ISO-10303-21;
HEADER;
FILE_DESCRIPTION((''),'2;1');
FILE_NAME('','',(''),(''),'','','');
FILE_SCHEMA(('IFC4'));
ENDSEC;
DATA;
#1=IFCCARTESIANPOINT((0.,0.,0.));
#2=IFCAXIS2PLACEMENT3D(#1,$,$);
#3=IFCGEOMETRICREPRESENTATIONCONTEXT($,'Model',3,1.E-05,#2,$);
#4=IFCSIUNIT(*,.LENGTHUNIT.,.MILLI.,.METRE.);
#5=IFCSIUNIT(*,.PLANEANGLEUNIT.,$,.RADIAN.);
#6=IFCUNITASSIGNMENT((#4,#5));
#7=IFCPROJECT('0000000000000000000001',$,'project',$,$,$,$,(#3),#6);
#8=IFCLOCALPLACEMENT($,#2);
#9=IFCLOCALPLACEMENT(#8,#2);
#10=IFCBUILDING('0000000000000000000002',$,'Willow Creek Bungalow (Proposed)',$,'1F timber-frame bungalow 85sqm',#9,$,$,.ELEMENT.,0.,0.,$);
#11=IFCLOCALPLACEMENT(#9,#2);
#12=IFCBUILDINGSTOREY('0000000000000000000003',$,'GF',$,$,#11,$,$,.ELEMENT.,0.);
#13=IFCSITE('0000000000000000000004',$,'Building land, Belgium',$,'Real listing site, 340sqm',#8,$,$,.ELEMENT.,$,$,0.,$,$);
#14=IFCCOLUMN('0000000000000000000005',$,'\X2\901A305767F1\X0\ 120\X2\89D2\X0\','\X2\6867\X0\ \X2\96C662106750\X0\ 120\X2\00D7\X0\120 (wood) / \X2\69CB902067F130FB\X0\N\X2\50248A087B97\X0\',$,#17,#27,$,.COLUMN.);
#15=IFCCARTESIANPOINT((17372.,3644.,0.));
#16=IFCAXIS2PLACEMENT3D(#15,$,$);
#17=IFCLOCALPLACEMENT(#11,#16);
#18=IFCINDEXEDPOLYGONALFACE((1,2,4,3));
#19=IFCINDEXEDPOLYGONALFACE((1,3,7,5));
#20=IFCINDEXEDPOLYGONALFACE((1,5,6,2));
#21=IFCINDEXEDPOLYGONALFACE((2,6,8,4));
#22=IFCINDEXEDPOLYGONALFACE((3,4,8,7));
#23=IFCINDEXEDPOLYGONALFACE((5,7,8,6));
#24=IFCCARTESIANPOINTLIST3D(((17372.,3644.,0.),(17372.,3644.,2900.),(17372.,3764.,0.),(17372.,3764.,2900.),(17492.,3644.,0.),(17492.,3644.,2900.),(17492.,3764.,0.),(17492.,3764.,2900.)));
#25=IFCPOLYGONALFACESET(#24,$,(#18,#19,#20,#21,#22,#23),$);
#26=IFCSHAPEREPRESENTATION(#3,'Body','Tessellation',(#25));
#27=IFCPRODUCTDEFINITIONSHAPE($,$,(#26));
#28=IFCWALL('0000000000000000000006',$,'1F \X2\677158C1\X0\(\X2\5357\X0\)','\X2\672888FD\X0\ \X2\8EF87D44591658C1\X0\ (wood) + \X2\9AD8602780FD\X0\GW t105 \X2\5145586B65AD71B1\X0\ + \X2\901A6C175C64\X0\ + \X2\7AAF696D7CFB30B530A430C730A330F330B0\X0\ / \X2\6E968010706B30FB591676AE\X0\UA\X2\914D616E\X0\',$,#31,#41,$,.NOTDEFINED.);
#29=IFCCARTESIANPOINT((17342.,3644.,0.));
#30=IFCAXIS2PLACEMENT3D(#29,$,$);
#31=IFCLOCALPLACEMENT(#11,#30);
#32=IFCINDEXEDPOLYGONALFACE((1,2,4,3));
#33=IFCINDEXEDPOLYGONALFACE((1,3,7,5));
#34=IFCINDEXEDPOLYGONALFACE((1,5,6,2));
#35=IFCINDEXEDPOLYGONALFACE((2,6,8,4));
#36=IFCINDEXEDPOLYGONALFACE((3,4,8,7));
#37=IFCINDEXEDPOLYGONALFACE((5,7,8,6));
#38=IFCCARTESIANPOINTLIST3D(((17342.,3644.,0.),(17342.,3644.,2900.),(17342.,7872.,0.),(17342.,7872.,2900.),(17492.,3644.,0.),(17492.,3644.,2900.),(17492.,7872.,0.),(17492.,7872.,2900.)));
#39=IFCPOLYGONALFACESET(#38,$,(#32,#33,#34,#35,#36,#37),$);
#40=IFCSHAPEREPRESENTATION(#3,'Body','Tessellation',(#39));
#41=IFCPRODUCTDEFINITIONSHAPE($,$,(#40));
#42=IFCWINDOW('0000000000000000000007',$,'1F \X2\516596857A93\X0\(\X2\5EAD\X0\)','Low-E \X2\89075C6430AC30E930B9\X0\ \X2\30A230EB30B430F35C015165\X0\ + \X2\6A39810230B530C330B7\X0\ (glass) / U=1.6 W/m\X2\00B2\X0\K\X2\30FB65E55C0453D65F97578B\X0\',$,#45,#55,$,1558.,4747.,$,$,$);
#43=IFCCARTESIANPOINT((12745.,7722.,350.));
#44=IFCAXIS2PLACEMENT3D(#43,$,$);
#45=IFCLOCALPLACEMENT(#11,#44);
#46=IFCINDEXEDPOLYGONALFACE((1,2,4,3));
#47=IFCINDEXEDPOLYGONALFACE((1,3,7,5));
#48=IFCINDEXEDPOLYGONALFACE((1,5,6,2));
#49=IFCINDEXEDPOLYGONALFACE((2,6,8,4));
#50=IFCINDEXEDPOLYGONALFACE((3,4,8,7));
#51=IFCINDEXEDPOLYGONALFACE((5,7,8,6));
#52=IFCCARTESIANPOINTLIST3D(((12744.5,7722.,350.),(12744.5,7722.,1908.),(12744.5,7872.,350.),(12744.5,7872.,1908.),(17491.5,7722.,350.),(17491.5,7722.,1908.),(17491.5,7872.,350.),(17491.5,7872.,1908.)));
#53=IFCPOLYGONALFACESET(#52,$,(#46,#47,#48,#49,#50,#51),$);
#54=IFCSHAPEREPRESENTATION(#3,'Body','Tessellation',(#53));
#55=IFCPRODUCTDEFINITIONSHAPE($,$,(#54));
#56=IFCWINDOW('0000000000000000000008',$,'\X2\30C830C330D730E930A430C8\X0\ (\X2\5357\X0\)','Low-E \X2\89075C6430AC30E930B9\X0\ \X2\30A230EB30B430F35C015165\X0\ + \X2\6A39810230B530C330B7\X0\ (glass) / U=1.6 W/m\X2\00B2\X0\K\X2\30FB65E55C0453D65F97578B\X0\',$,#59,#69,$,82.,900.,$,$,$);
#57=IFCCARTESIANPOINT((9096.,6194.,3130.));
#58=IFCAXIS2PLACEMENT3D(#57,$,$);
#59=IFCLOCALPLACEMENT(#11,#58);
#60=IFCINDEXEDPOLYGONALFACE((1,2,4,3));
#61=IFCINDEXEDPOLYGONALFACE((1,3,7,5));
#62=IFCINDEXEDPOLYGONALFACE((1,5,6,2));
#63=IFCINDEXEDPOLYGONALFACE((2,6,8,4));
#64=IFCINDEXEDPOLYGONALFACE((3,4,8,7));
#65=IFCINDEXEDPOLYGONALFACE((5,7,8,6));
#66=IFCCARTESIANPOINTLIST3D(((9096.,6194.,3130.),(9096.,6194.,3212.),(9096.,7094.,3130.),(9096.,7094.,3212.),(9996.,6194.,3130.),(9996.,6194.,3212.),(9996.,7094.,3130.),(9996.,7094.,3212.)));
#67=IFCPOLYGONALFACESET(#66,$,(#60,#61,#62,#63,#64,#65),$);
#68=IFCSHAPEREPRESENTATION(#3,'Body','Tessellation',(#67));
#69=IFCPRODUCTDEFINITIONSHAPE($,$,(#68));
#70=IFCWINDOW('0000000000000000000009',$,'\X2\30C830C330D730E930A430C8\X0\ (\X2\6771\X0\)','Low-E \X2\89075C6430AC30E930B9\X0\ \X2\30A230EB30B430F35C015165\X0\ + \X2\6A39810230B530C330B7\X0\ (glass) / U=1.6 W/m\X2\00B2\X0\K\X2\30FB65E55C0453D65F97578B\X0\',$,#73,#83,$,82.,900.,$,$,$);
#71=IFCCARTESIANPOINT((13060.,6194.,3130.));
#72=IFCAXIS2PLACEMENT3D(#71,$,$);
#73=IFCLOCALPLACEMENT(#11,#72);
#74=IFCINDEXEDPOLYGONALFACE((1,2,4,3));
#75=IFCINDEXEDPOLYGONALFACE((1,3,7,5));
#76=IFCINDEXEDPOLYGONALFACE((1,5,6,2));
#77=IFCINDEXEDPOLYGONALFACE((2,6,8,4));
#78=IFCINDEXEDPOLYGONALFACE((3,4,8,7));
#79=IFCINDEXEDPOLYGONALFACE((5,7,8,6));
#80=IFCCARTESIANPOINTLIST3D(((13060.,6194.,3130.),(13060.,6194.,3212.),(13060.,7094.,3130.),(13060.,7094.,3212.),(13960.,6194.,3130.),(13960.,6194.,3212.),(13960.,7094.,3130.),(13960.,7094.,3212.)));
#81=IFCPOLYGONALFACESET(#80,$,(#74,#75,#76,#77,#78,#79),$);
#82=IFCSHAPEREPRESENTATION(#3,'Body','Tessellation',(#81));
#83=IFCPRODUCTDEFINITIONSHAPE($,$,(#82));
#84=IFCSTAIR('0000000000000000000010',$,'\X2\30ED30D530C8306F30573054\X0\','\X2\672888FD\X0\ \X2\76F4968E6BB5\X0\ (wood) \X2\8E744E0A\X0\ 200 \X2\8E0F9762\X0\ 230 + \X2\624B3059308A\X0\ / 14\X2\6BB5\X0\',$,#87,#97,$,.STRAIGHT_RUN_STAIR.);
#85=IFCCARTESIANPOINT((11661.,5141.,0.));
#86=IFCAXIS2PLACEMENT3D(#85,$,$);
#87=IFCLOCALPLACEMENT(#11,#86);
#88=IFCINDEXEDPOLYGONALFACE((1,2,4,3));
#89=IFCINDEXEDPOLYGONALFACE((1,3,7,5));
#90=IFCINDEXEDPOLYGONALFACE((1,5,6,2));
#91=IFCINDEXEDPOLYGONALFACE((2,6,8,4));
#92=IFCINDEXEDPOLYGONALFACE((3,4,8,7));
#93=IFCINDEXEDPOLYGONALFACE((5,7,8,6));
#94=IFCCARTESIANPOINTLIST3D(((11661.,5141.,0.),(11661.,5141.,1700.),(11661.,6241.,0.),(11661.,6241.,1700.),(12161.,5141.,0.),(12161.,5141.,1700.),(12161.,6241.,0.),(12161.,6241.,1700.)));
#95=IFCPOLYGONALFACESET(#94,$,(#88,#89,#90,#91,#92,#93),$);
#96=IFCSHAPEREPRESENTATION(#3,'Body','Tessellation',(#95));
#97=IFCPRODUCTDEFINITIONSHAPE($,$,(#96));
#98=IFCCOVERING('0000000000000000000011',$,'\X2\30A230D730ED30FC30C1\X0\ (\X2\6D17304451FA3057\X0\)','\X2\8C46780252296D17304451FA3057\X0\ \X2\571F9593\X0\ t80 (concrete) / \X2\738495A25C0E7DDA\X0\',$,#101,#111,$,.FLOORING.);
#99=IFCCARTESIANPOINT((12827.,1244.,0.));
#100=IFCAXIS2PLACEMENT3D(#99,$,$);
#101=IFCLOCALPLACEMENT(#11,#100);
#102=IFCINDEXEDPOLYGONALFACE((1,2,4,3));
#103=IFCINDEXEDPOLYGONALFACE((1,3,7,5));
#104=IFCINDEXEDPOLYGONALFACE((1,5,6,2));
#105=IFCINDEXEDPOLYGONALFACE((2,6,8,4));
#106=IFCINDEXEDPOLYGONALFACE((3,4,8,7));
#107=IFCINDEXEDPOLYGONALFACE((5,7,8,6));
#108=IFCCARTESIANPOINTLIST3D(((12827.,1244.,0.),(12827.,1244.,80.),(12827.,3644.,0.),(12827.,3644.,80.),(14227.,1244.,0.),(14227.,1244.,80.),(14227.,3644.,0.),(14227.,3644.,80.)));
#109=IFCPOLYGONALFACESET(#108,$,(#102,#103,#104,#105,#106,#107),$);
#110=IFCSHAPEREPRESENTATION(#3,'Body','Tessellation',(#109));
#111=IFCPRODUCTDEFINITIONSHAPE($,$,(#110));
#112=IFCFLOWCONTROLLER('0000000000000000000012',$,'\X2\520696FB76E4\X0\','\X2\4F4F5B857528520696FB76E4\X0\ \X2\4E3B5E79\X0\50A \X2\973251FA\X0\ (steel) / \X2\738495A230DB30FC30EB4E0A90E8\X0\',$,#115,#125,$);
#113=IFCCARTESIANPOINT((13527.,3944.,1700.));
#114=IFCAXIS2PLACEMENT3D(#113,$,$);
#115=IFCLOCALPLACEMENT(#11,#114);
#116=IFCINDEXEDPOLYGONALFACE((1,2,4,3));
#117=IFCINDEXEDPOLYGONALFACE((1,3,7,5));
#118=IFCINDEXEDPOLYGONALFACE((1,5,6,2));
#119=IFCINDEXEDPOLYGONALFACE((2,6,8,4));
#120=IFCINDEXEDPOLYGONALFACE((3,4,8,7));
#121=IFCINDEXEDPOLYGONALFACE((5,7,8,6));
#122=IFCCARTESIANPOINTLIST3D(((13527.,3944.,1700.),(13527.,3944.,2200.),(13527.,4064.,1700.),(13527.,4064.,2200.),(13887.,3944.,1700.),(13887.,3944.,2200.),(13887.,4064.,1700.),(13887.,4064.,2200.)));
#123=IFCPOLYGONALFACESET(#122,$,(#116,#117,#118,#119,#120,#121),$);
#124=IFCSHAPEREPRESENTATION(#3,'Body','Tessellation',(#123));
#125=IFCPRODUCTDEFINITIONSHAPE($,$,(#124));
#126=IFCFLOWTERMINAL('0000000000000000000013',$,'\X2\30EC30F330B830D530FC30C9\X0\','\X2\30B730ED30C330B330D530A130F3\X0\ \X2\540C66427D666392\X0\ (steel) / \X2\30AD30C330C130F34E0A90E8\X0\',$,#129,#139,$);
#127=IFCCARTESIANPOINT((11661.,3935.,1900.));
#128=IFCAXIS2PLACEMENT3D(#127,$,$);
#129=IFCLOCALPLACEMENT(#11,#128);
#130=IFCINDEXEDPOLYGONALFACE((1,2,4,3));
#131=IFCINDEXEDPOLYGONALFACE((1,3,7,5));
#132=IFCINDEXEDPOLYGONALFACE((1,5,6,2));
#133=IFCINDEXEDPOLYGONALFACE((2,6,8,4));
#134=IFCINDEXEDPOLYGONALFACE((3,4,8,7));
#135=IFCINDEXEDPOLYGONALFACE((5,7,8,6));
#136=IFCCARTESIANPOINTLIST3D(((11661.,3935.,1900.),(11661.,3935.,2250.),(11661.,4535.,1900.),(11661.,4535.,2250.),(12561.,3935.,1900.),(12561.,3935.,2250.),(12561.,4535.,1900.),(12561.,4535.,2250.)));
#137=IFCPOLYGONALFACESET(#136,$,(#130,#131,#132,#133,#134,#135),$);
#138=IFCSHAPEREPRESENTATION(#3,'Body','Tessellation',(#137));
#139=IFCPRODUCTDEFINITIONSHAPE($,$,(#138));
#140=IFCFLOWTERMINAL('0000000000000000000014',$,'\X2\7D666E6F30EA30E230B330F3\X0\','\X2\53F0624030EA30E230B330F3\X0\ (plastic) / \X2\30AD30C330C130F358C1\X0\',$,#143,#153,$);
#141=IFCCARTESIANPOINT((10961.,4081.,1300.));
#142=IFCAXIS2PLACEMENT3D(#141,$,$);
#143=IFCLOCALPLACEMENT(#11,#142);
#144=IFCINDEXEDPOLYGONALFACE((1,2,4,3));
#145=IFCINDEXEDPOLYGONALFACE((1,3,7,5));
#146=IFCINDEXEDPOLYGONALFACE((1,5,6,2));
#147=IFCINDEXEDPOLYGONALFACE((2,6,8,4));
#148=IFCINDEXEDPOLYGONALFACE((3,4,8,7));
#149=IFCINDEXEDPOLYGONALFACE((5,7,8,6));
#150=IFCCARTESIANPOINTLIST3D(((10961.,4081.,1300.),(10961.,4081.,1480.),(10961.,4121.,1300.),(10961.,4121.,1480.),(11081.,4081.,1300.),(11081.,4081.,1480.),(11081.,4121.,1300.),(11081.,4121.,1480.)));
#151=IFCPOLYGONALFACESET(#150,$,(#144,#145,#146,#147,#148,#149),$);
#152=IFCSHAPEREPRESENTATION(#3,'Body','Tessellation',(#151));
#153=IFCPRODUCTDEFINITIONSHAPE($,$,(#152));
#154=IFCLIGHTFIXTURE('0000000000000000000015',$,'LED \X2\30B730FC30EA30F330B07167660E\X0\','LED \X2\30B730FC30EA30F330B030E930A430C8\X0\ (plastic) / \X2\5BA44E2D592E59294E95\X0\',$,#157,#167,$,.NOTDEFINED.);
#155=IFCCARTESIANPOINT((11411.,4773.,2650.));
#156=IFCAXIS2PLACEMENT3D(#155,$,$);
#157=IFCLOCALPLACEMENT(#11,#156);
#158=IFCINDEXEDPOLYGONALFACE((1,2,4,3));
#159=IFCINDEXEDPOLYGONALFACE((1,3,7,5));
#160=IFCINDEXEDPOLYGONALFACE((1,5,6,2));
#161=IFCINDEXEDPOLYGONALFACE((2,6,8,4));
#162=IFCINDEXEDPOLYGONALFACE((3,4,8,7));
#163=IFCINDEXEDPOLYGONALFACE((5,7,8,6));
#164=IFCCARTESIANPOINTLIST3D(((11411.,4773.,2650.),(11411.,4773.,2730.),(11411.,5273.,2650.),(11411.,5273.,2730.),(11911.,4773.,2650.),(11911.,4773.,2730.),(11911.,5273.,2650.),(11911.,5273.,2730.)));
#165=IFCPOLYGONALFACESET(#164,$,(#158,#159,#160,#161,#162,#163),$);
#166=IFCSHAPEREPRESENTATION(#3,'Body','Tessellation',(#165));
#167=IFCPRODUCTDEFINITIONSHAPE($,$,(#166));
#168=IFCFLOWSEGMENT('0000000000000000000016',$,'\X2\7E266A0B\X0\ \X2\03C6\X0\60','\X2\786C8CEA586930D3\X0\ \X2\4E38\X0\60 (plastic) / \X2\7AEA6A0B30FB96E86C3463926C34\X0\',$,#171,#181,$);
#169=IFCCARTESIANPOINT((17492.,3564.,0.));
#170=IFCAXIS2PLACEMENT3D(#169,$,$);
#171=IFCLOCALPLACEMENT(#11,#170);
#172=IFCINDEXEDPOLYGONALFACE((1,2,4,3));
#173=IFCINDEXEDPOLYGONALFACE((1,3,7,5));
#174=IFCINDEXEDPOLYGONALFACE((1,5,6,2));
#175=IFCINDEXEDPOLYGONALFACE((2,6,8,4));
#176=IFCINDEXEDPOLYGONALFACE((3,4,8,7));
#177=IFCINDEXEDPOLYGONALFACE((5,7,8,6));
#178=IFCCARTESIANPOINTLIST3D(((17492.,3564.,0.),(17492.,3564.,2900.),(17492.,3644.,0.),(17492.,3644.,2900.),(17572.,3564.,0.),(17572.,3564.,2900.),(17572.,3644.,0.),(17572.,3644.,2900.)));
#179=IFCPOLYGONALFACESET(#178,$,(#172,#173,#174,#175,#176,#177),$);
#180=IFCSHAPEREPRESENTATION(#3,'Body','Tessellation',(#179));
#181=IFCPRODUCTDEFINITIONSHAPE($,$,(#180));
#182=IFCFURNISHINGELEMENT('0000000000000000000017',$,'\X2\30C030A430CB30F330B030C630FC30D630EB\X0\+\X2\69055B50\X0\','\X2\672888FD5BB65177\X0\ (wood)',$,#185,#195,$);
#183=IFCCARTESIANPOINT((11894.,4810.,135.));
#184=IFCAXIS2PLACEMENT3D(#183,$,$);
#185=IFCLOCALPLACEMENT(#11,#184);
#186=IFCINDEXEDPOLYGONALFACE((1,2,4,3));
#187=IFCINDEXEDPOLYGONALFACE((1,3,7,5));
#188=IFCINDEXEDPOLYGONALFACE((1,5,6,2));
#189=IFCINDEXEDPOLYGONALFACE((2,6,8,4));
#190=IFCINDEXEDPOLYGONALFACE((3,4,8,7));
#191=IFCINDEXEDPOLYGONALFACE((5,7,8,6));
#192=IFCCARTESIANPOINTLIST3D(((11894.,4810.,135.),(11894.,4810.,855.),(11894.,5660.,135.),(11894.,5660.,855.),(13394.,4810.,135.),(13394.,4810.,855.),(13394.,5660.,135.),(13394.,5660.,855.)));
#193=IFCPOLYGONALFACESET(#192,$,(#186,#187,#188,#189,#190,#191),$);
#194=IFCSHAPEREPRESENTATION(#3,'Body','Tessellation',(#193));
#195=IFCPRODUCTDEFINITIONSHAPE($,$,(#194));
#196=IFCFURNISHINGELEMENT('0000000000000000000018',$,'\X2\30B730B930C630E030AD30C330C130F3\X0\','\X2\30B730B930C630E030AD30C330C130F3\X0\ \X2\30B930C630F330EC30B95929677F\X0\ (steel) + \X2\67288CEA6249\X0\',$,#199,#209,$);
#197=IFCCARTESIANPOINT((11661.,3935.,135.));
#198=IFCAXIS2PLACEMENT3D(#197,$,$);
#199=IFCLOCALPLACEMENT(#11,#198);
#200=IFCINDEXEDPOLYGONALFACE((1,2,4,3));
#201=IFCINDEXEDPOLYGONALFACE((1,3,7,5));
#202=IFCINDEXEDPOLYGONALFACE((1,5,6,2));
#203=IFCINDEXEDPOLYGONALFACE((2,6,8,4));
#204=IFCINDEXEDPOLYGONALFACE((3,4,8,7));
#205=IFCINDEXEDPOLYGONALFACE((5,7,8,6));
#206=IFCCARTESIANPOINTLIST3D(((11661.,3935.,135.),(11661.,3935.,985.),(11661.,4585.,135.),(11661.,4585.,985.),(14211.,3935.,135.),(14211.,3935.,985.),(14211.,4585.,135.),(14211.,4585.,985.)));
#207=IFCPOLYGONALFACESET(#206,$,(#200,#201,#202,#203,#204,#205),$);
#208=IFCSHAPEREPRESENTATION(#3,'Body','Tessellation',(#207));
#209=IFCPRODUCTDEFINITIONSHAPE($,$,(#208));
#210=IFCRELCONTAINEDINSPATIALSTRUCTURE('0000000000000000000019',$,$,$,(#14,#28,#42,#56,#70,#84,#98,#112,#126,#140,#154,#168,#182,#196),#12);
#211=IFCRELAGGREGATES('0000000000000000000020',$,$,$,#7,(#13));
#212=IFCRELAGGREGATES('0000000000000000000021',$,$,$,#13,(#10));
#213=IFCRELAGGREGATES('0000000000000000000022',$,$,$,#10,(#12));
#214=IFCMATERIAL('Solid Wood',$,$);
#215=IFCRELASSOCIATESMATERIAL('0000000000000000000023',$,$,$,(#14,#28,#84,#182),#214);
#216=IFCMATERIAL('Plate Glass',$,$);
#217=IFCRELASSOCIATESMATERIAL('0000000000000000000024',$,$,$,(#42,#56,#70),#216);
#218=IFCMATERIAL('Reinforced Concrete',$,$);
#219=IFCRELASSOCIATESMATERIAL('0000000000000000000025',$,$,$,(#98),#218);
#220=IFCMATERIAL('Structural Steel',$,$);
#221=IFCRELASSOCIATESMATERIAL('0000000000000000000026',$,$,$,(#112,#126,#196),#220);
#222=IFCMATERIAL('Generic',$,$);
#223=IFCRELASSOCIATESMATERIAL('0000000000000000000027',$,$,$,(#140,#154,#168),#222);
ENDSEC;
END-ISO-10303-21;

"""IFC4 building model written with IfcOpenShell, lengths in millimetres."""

from ifc_helpers import new_model, si_unit, frame, frame_2d, origin, place, context, project, spatial, rectangle, extrude, material, element, fill, save


model = new_model("IFC4")

# Units and contexts
model_context = context("Model", 3, precision=1e-05, world=origin())
ifc_project = project(units=[si_unit("LENGTHUNIT", "METRE", prefix="MILLI"), si_unit("PLANEANGLEUNIT", "RADIAN")], contexts=[model_context])

# Site, building, storey
site_placement = place(None, origin())
site = spatial("IfcSite", under=ifc_project, at=site_placement, Name="Building land, Belgium", ObjectType="Real listing site, 340sqm", CompositionType="ELEMENT", RefElevation=0.0)
building_placement = place(site_placement, origin())
building = spatial("IfcBuilding", under=site, at=building_placement, Name="Willow Creek Bungalow (Proposed)", ObjectType="1F timber-frame bungalow 85sqm", CompositionType="ELEMENT", ElevationOfRefHeight=0.0, ElevationOfTerrain=0.0)
storey_placement = place(building_placement, origin())
storey = spatial("IfcBuildingStorey", under=building, at=storey_placement, Name="GF", CompositionType="ELEMENT", Elevation=0.0)

# Column
ifc_material_1 = material(Name="Solid Wood")
column_1_placement = place(storey_placement, frame((17372.0, 3644.0, 0.0)))
element("IfcColumn", 1, at=column_1_placement, inside=storey, material=ifc_material_1, Name="通し柱 120角", Description="桧 集成材 120×120 (wood) / 構造柱・N値計算", PredefinedType="COLUMN", context=model_context, shape_type="SweptSolid", body=[
    extrude(rectangle(XDim=120.0, YDim=120.0, at=frame_2d((60.0, 60.0))), frame((17372.0, 3644.0, 0.0)), (0.0, 0.0, 1.0), 2900.0),
])

# Wall, opening, window
wall_1_placement = place(storey_placement, frame((17342.0, 3644.0, 0.0)))
wall_1 = element("IfcWall", 2, at=wall_1_placement, inside=storey, material=ifc_material_1, Name="1F 東壁(南)", Description="木製 軸組外壁 (wood) + 高性能GW t105 充填断熱 + 通気層 + 窯業系サイディング / 準耐火・外皮UA配慮", PredefinedType="NOTDEFINED", context=model_context, shape_type="SweptSolid", body=[
    extrude(rectangle(XDim=150.0, YDim=4228.0, at=frame_2d((75.0, 2114.0))), frame((17342.0, 3644.0, 0.0)), (0.0, 0.0, 1.0), 2900.0),
])
opening_1_placement = place(storey_placement, frame((12745.0, 7722.0, 350.0)))
opening_1 = element("IfcOpeningElement", 3, at=opening_1_placement, cuts=wall_1, PredefinedType="NOTDEFINED", context=model_context, shape_type="SweptSolid", body=[
    extrude(rectangle(XDim=4747.0, YDim=150.0, at=frame_2d((2373.0, 75.0))), frame((12745.0, 7722.0, 350.0)), (0.0, 0.0, 1.0), 1558.0),
])
ifc_material_2 = material(Name="Plate Glass")
window_1_placement = place(storey_placement, frame((12745.0, 7722.0, 350.0)))
window_1 = element("IfcWindow", 4, at=window_1_placement, inside=storey, material=ifc_material_2, Name="1F 入隅窓(庭)", Description="Low-E 複層ガラス アルゴン封入 + 樹脂サッシ (glass) / U=1.6 W/m²K・日射取得型", OverallHeight=1558.0, OverallWidth=4747.0, context=model_context, shape_type="SweptSolid", body=[
    extrude(rectangle(XDim=4747.0, YDim=150.0, at=frame_2d((2373.0, 75.0))), frame((12745.0, 7722.0, 350.0)), (0.0, 0.0, 1.0), 1558.0),
])
fill(opening_1, window_1)

# Windows
window_2_placement = place(storey_placement, frame((9096.0, 6194.0, 3130.0)))
element("IfcWindow", 5, at=window_2_placement, inside=storey, material=ifc_material_2, Name="トップライト (南)", Description="Low-E 複層ガラス アルゴン封入 + 樹脂サッシ (glass) / U=1.6 W/m²K・日射取得型", OverallHeight=82.0, OverallWidth=900.0, context=model_context, shape_type="SweptSolid", body=[
    extrude(rectangle(XDim=900.0, YDim=900.0, at=frame_2d((450.0, 450.0))), frame((9096.0, 6194.0, 3130.0)), (0.0, 0.0, 1.0), 82.0),
])
window_3_placement = place(storey_placement, frame((13060.0, 6194.0, 3130.0)))
element("IfcWindow", 6, at=window_3_placement, inside=storey, material=ifc_material_2, Name="トップライト (東)", Description="Low-E 複層ガラス アルゴン封入 + 樹脂サッシ (glass) / U=1.6 W/m²K・日射取得型", OverallHeight=82.0, OverallWidth=900.0, context=model_context, shape_type="SweptSolid", body=[
    extrude(rectangle(XDim=900.0, YDim=900.0, at=frame_2d((450.0, 450.0))), frame((13060.0, 6194.0, 3130.0)), (0.0, 0.0, 1.0), 82.0),
])

# Stair
stair_placement = place(storey_placement, frame((11661.0, 5141.0, 0.0)))
element("IfcStair", 7, at=stair_placement, inside=storey, material=ifc_material_1, Name="ロフトはしご", Description="木製 直階段 (wood) 蹴上 200 踏面 230 + 手すり / 14段", PredefinedType="STRAIGHT_RUN_STAIR", context=model_context, shape_type="SweptSolid", body=[
    extrude(rectangle(XDim=500.0, YDim=1100.0, at=frame_2d((250.0, 550.0))), frame((11661.0, 5141.0, 0.0)), (0.0, 0.0, 1.0), 1700.0),
])

# Covering
ifc_material_3 = material(Name="Reinforced Concrete")
covering_placement = place(storey_placement, frame((12827.0, 1244.0, 0.0)))
element("IfcCovering", 8, at=covering_placement, inside=storey, material=ifc_material_3, Name="アプローチ (洗い出し)", Description="豆砂利洗い出し 土間 t80 (concrete) / 玄関導線", PredefinedType="FLOORING", context=model_context, shape_type="SweptSolid", body=[
    extrude(rectangle(XDim=1400.0, YDim=2400.0, at=frame_2d((700.0, 1200.0))), frame((12827.0, 1244.0, 0.0)), (0.0, 0.0, 1.0), 80.0),
])

# Flow controller
ifc_material_4 = material(Name="Structural Steel")
flow_controller_placement = place(storey_placement, frame((13527.0, 3944.0, 1700.0)))
element("IfcFlowController", 9, at=flow_controller_placement, inside=storey, material=ifc_material_4, Name="分電盤", Description="住宅用分電盤 主幹50A 露出 (steel) / 玄関ホール上部", context=model_context, shape_type="SweptSolid", body=[
    extrude(rectangle(XDim=360.0, YDim=120.0, at=frame_2d((180.0, 60.0))), frame((13527.0, 3944.0, 1700.0)), (0.0, 0.0, 1.0), 500.0),
])

# Flow terminals
flow_terminal_1_placement = place(storey_placement, frame((11661.0, 3935.0, 1900.0)))
element("IfcFlowTerminal", 10, at=flow_terminal_1_placement, inside=storey, material=ifc_material_4, Name="レンジフード", Description="シロッコファン 同時給排 (steel) / キッチン上部", context=model_context, shape_type="SweptSolid", body=[
    extrude(rectangle(XDim=900.0, YDim=600.0, at=frame_2d((450.0, 300.0))), frame((11661.0, 3935.0, 1900.0)), (0.0, 0.0, 1.0), 350.0),
])
ifc_material_5 = material(Name="Generic")
flow_terminal_2_placement = place(storey_placement, frame((10961.0, 4081.0, 1300.0)))
element("IfcFlowTerminal", 11, at=flow_terminal_2_placement, inside=storey, material=ifc_material_5, Name="給湯リモコン", Description="台所リモコン (plastic) / キッチン壁", context=model_context, shape_type="SweptSolid", body=[
    extrude(rectangle(XDim=120.0, YDim=40.0, at=frame_2d((60.0, 20.0))), frame((10961.0, 4081.0, 1300.0)), (0.0, 0.0, 1.0), 180.0),
])

# Light fixture
light_fixture_placement = place(storey_placement, frame((11411.0, 4773.0, 2650.0)))
element("IfcLightFixture", 12, at=light_fixture_placement, inside=storey, material=ifc_material_5, Name="LED シーリング照明", Description="LED シーリングライト (plastic) / 室中央天井", PredefinedType="NOTDEFINED", context=model_context, shape_type="SweptSolid", body=[
    extrude(rectangle(XDim=500.0, YDim=500.0, at=frame_2d((250.0, 250.0))), frame((11411.0, 4773.0, 2650.0)), (0.0, 0.0, 1.0), 80.0),
])

# Flow segment
flow_segment_placement = place(storey_placement, frame((17492.0, 3564.0, 0.0)))
element("IfcFlowSegment", 13, at=flow_segment_placement, inside=storey, material=ifc_material_5, Name="縦樋 φ60", Description="硬質塩ビ 丸60 (plastic) / 竪樋・雨水排水", context=model_context, shape_type="SweptSolid", body=[
    extrude(rectangle(XDim=80.0, YDim=80.0, at=frame_2d((40.0, 40.0))), frame((17492.0, 3564.0, 0.0)), (0.0, 0.0, 1.0), 2900.0),
])

# Furnishing elements
furnishing_1_placement = place(storey_placement, frame((11894.0, 4810.0, 135.0)))
element("IfcFurnishingElement", 14, at=furnishing_1_placement, inside=storey, material=ifc_material_1, Name="ダイニングテーブル+椅子", Description="木製家具 (wood)", context=model_context, shape_type="SweptSolid", body=[
    extrude(rectangle(XDim=1500.0, YDim=850.0, at=frame_2d((750.0, 425.0))), frame((11894.0, 4810.0, 135.0)), (0.0, 0.0, 1.0), 720.0),
])
furnishing_2_placement = place(storey_placement, frame((11661.0, 3935.0, 135.0)))
element("IfcFurnishingElement", 15, at=furnishing_2_placement, inside=storey, material=ifc_material_4, Name="システムキッチン", Description="システムキッチン ステンレス天板 (steel) + 木質扉", context=model_context, shape_type="SweptSolid", body=[
    extrude(rectangle(XDim=2550.0, YDim=650.0, at=frame_2d((1275.0, 325.0))), frame((11661.0, 3935.0, 135.0)), (0.0, 0.0, 1.0), 850.0),
])

save(model, "model.ifc")
